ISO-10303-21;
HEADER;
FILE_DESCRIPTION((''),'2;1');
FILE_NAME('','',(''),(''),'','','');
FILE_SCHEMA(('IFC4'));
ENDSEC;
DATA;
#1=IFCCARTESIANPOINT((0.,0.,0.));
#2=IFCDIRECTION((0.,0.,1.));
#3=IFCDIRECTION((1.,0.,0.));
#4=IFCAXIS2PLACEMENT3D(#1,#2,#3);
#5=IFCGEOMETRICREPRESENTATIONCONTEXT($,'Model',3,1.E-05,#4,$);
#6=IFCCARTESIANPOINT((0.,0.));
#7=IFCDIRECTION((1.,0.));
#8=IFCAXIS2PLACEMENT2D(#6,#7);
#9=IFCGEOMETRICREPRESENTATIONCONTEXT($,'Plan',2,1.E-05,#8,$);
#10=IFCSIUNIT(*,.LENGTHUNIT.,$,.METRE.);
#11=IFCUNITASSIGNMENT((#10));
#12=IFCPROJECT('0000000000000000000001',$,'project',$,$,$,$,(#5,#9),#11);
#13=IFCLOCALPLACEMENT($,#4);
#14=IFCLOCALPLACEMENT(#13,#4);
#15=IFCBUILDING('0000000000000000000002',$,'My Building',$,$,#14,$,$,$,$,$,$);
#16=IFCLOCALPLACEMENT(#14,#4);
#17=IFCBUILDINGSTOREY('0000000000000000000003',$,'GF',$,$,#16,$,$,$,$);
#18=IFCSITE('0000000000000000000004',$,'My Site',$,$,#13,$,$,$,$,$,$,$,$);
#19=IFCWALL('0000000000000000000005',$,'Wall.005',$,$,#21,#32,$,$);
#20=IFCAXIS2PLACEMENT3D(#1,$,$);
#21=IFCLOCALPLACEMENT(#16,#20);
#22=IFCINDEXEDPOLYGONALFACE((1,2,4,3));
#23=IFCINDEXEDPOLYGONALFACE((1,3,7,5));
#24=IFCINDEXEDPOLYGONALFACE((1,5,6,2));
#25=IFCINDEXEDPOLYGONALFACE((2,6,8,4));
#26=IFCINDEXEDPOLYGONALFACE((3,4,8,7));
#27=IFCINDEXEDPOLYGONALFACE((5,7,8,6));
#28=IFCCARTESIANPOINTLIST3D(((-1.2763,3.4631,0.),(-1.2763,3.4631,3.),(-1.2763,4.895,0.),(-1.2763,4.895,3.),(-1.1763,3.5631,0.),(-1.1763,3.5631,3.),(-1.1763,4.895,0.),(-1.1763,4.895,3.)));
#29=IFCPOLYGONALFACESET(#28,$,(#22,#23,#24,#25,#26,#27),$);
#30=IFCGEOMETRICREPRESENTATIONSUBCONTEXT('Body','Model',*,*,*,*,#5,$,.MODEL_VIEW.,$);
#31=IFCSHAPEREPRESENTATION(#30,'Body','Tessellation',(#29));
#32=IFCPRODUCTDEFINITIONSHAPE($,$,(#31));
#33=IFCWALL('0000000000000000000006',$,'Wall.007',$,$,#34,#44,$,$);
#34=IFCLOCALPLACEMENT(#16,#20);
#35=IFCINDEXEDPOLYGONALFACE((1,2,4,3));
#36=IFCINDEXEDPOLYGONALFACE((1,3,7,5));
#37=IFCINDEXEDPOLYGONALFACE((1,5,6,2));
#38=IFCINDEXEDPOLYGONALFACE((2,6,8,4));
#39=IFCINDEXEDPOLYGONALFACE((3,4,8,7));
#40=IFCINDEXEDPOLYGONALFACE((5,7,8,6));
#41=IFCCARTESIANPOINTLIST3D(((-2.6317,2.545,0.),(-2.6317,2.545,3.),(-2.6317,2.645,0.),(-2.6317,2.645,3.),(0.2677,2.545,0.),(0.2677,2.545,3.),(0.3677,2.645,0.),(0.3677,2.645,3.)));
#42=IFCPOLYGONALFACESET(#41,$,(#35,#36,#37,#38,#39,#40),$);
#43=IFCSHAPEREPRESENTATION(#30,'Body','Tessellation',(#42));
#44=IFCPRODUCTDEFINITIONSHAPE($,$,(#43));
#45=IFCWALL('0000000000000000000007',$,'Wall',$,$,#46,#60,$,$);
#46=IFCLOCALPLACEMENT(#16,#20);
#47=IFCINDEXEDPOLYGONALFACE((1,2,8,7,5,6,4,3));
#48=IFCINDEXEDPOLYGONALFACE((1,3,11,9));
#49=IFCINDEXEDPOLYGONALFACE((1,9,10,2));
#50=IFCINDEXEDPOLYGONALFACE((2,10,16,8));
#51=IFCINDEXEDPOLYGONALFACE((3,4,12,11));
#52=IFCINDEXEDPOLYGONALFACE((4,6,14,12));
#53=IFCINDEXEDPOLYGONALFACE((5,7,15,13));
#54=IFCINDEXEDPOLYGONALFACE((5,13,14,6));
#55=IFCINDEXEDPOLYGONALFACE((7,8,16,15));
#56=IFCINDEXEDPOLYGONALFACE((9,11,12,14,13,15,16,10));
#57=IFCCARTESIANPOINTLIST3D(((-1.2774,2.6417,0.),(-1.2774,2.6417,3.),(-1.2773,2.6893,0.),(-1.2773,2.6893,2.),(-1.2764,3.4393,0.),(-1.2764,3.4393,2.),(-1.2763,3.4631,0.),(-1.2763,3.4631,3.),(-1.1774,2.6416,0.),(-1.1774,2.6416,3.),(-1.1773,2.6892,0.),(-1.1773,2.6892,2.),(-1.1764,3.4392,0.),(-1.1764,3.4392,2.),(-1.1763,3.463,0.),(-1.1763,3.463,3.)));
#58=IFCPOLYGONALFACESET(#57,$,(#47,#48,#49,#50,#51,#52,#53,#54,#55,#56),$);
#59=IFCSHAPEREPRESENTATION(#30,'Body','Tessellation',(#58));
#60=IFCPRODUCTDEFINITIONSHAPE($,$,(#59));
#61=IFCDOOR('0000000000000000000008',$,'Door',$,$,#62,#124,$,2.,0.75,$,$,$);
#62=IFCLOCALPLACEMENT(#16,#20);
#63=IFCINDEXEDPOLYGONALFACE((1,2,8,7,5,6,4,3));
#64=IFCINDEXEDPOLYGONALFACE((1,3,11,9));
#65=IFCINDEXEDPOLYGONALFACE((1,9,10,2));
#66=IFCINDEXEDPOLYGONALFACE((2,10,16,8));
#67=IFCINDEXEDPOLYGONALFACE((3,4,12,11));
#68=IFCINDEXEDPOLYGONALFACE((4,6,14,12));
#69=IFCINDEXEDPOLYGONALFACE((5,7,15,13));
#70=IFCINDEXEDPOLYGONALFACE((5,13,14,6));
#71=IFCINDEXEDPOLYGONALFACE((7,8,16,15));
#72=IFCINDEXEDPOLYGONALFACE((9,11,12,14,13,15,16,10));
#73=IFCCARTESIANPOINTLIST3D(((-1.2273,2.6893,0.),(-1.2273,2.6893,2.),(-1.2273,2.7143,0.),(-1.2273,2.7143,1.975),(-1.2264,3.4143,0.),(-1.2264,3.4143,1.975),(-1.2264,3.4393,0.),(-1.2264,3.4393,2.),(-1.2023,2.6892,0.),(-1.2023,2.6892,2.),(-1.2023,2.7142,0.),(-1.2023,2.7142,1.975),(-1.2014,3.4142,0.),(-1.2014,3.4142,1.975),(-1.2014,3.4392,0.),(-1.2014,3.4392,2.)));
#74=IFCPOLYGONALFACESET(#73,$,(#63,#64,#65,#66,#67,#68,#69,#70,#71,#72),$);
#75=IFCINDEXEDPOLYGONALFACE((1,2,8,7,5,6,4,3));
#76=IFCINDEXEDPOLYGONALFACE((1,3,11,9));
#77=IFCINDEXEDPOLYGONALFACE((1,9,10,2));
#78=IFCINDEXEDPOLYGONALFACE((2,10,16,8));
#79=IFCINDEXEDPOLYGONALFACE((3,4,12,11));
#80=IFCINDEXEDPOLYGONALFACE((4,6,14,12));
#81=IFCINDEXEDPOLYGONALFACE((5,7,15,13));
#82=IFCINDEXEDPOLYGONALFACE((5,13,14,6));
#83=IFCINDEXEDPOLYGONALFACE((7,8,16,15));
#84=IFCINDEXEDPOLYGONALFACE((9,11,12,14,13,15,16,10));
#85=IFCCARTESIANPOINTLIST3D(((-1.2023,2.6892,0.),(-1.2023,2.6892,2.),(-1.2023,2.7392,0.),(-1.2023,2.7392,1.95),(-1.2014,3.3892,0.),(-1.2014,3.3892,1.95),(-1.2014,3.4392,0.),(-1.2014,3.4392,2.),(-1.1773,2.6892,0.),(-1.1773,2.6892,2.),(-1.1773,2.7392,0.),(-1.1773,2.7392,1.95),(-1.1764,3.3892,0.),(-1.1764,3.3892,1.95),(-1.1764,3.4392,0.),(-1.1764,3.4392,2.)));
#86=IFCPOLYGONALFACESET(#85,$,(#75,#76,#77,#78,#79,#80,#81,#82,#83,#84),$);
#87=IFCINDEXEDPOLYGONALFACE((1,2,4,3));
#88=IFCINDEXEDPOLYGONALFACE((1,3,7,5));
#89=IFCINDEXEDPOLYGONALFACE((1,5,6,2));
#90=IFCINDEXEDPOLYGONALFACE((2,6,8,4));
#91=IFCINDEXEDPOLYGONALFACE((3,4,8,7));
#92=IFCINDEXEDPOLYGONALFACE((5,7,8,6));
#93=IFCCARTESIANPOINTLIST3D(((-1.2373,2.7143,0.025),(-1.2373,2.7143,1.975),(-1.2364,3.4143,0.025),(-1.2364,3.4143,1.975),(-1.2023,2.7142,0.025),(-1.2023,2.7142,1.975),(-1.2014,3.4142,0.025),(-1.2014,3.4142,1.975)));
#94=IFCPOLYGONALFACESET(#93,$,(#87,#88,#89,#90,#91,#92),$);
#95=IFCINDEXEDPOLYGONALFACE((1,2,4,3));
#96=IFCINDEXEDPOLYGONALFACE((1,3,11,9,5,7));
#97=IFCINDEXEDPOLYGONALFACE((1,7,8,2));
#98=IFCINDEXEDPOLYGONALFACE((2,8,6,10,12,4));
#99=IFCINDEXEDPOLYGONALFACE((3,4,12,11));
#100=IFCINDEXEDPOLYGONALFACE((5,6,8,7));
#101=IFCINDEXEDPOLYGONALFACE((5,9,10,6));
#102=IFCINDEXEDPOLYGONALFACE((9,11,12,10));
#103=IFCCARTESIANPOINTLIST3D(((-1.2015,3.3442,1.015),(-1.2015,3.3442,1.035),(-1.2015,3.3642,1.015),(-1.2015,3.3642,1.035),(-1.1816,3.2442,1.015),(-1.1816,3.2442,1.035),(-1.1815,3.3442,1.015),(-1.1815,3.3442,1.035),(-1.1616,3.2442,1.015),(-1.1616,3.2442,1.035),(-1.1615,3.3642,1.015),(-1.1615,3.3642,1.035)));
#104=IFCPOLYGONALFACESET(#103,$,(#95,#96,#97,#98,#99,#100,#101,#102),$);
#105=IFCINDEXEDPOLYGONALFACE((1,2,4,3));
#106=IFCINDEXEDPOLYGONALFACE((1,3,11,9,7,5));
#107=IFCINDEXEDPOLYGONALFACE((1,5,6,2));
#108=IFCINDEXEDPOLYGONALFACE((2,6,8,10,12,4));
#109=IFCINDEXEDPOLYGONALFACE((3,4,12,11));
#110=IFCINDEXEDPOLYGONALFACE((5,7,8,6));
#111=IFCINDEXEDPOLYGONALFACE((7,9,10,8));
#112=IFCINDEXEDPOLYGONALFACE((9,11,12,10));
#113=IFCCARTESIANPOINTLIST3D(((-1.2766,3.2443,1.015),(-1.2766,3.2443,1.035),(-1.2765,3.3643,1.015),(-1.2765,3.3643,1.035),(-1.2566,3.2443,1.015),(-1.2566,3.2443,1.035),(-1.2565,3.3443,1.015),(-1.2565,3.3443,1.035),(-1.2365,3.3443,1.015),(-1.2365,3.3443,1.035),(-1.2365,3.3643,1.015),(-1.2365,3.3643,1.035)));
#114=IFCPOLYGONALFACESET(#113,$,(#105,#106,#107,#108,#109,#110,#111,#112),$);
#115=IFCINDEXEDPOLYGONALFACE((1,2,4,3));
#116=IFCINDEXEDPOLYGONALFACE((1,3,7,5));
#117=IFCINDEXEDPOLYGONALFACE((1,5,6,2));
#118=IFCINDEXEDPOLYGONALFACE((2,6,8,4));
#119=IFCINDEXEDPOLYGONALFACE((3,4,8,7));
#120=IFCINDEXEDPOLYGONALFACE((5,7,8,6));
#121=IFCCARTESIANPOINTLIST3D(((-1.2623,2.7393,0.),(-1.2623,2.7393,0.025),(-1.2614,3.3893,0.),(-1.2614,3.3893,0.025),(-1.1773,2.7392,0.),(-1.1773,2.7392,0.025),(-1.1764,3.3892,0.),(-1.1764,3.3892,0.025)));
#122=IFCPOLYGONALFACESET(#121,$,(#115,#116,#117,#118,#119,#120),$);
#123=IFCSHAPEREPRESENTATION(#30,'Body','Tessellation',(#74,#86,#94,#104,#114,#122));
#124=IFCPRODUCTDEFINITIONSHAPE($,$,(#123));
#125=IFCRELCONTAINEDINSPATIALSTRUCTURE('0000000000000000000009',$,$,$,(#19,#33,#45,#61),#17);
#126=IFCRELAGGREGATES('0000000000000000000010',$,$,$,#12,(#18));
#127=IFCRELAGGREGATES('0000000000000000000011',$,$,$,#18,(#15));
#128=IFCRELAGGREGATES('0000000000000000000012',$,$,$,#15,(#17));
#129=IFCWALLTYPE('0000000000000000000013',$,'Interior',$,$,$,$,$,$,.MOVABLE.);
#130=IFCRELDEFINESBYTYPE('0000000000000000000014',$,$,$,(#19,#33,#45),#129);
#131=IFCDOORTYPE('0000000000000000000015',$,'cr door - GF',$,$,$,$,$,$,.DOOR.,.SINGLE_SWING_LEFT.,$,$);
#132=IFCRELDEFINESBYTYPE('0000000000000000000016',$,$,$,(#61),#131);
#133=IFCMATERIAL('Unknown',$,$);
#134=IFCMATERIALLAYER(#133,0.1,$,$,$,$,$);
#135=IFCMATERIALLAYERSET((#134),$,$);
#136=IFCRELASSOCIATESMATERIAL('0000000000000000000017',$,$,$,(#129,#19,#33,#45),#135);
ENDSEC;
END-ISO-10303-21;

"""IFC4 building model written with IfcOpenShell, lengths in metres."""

from ifc_helpers import new_model, entity, si_unit, frame, origin_with_axes, origin_2d_with_axis, place, context, subcontext, project, spatial, line, indexed_curve, outline, extrude, shape, source, transform, mapped, material, layer, layer_set, layer_usage, type_object, type_shapes, element, fill, save


model = new_model("IFC4")

# Units and contexts
model_context = context("Model", 3, precision=1e-05, world=origin_with_axes())
plan_context = context("Plan", 2, precision=1e-05, world=origin_2d_with_axis())
body_context_1 = subcontext(model_context, "Body", "Model", "MODEL_VIEW")
body_context_2 = subcontext(plan_context, "Body", "Plan", "PLAN_VIEW")
ifc_project = project(units=[si_unit("LENGTHUNIT", "METRE")], contexts=[model_context, plan_context])

# Site, building, storey
site_placement = place(None, origin_with_axes())
site = spatial("IfcSite", under=ifc_project, at=site_placement, Name="My Site")
building_placement = place(site_placement, origin_with_axes())
building = spatial("IfcBuilding", under=site, at=building_placement, Name="My Building")
storey_placement = place(building_placement, origin_with_axes())
storey = spatial("IfcBuildingStorey", under=building, at=storey_placement, Name="GF")

# Shared definitions
ifc_material = material(Name="Unknown")

# Walls
ifc_layer_1 = layer(ifc_material, 0.1)
ifc_layer_set_1 = layer_set([ifc_layer_1])
wall_type_1 = type_object("IfcWallType", Name="Interior", PredefinedType="MOVABLE", material=ifc_layer_set_1)
ifc_layer_usage_1 = layer_usage(ifc_layer_set_1, "AXIS2", "POSITIVE", 0.0)
wall_1_placement = place(storey_placement, frame((-1.1763, 3.5631, 0.0), z_axis=(0.0, 0.0, 1.0), x_axis=(0.0, 1.0, 0.0)))
element("IfcWall", 1, at=wall_1_placement, inside=storey, type_object=wall_type_1, material=ifc_layer_usage_1, Name="Wall.005", context=body_context_1, shape_type="SweptSolid", body=[
    extrude(outline(indexed_curve([(0.0, 0.0), (-0.1, 0.1), (1.3318, 0.1), (1.3318, 0.0)], segments=[line(1, 2, 3, 4, 1)])), origin_with_axes(), (0.0, 0.0, 1.0), 3.0),
])
ifc_layer_usage_2 = layer_usage(ifc_layer_set_1, "AXIS2", "POSITIVE", 0.0)
wall_2_placement = place(storey_placement, frame((0.3677, 2.645, 0.0), z_axis=(0.0, 0.0, 1.0), x_axis=(-1.0, 0.0, 0.0)))
element("IfcWall", 2, at=wall_2_placement, inside=storey, type_object=wall_type_1, material=ifc_layer_usage_2, Name="Wall.007", context=body_context_1, shape_type="SweptSolid", body=[
    extrude(outline(indexed_curve([(0.0, 0.0), (0.1, 0.1), (2.9994, 0.1), (2.9994, 0.0)], segments=[line(1, 2, 3, 4, 1)])), origin_with_axes(), (0.0, 0.0, 1.0), 3.0),
])

# Wall, opening, door
ifc_layer_usage_3 = layer_usage(ifc_layer_set_1, "AXIS2", "POSITIVE", 0.0)
wall_3_placement = place(storey_placement, frame((-1.2763, 3.4631, 0.0), z_axis=(0.0, 0.0, 1.0), x_axis=(-0.001302, -0.999999, 0.0)))
wall_3 = element("IfcWall", 3, at=wall_3_placement, inside=storey, type_object=wall_type_1, material=ifc_layer_usage_3, Name="Wall", context=body_context_1, shape_type="SweptSolid", body=[
    extrude(outline(indexed_curve([(0.0, 0.0), (0.0, 0.1), (0.8215, 0.1), (0.8215, 0.0)], segments=[line(1, 2, 3, 4, 1)])), origin_with_axes(), (0.0, 0.0, 1.0), 3.0),
])
shared_shape_1 = source(origin_with_axes(), body_context_1, "Body", "SweptSolid", [
    extrude(outline(indexed_curve([(0.0, 0.0), (0.75, 0.0), (0.75, 2.0), (0.0, 2.0)], segments=[line(1, 2, 3, 4, 1)])), frame((0.0, -0.6, 0.0), z_axis=(0.0, -1.0, 0.0), x_axis=(1.0, 0.0, 0.0)), (0.0, 0.0, -1.0), 1.2),
])
opening_1_placement = place(wall_3_placement, frame((0.7738, 0.1, 0.0), z_axis=(0.0, 0.0, 1.0), x_axis=(-1.0, 0.0, 0.0)))
opening_1 = element("IfcOpeningElement", 4, at=opening_1_placement, cuts=wall_3, PredefinedType="OPENING", context=body_context_1, shape_type="MappedRepresentation", body=[
    mapped(shared_shape_1, transform((0.0, 0.0, 0.0), x_axis=(1.0, 0.0, 0.0), y_axis=(0.0, 1.0, 0.0), z_axis=(0.0, 0.0, 1.0), scale=1.0)),
])
door_type_1 = type_object("IfcDoorType", Name="cr door - GF", OperationType="SINGLE_SWING_LEFT", PredefinedType="DOOR")
shared_shape_2 = source(origin_with_axes(), body_context_1, "Body", "SweptSolid", [
    extrude(outline(indexed_curve([(0.0, 0.0), (0.0, 2.0), (0.75, 2.0), (0.75, 0.0), (0.725, 0.0), (0.725, 1.975), (0.025, 1.975), (0.025, 0.0)], segments=[line(1, 2, 3, 4, 5, 6, 7, 8, 1)])), frame((0.0, 0.025, 0.0), z_axis=(0.0, -1.0, 0.0), x_axis=(1.0, 0.0, 0.0)), (0.0, 0.0, -1.0), 0.025),
    extrude(outline(indexed_curve([(0.0, 0.0), (0.0, 2.0), (0.75, 2.0), (0.75, 0.0), (0.7, 0.0), (0.7, 1.95), (0.05, 1.95), (0.05, 0.0)], segments=[line(1, 2, 3, 4, 5, 6, 7, 8, 1)])), frame((0.0, 0.0, 0.0), z_axis=(0.0, -1.0, 0.0), x_axis=(1.0, 0.0, 0.0)), (0.0, 0.0, -1.0), 0.025),
    extrude(outline(indexed_curve([(0.0, 0.0), (0.7, 0.0), (0.7, 0.035), (0.0, 0.035)], segments=[line(1, 2, 3, 4, 1)])), frame((0.025, 0.025, 0.025), z_axis=(0.0, 0.0, 1.0), x_axis=(1.0, 0.0, 0.0)), (0.0, 0.0, 1.0), 1.95),
    extrude(outline(indexed_curve([(0.0, 0.0), (0.0, -0.04), (-0.12, -0.04), (-0.12, -0.02), (-0.02, -0.02), (-0.02, 0.0)], segments=[line(1, 2, 3, 4, 5, 6, 1)])), frame((0.675, 0.025, 1.015), z_axis=(0.0, 0.0, 1.0), x_axis=(1.0, 0.0, 0.0)), (0.0, 0.0, 1.0), 0.02),
    extrude(outline(indexed_curve([(0.0, 0.0), (0.0, 0.04), (-0.12, 0.04), (-0.12, 0.02), (-0.02, 0.02), (-0.02, 0.0)], segments=[line(1, 2, 3, 4, 5, 6, 1)])), frame((0.675, 0.06, 1.015), z_axis=(0.0, 0.0, 1.0), x_axis=(1.0, 0.0, 0.0)), (0.0, 0.0, 1.0), 0.02),
    extrude(outline(indexed_curve([(0.0, 0.0), (0.65, 0.0), (0.65, 0.085), (0.0, 0.085)], segments=[line(1, 2, 3, 4, 1)])), frame((0.05, 0.0, 0.0), z_axis=(0.0, 0.0, 1.0), x_axis=(1.0, 0.0, 0.0)), (0.0, 0.0, 1.0), 0.025),
])
shared_shape_3 = source(origin_with_axes(), body_context_2, "Body", "Curve2D", [
    entity("IfcIndexedPolyCurve", entity("IfcCartesianPointList2D", [[0.0, 0.0], [0.0, 0.05], [0.025, 0.05], [0.025, 0.025], [0.05, 0.025], [0.05, 0.0]]), [entity("IfcLineIndex", [1, 2, 3, 4, 5, 6, 1])]),
    entity("IfcIndexedPolyCurve", entity("IfcCartesianPointList2D", [[0.75, 0.0], [0.75, 0.05], [0.725, 0.05], [0.725, 0.025], [0.7, 0.025], [0.7, 0.0]]), [entity("IfcLineIndex", [1, 2, 3, 4, 5, 6, 1])]),
    entity("IfcTrimmedCurve", entity("IfcEllipse", entity("IfcAxis2Placement2D", entity("IfcCartesianPoint", [0.06, 0.05]), entity("IfcDirection", [1.0, 0.0])), 0.665, 0.7), [entity("IfcCartesianPoint", [0.725, 0.05])], [entity("IfcCartesianPoint", [0.06, 0.75])], True, "CARTESIAN"),
    entity("IfcIndexedPolyCurve", entity("IfcCartesianPointList2D", [[0.025, 0.05], [0.06, 0.05], [0.06, 0.75], [0.025, 0.75]]), [entity("IfcLineIndex", [1, 2, 3, 4, 1])]),
])
type_shapes(door_type_1, [shared_shape_2, shared_shape_3])
door_1_placement = place(opening_1_placement, frame((0.0, 0.0, 0.0), z_axis=(0.0, 0.0, 1.0), x_axis=(1.0, 0.0, 0.0)))
door_1 = element("IfcDoor", 5, at=door_1_placement, inside=storey, type_object=door_type_1, Name="Door", OverallHeight=2.0, OverallWidth=0.75, shapes=[
    shape(body_context_1, "Body", "MappedRepresentation", [mapped(shared_shape_2, transform((0.0, 0.0, 0.0), x_axis=(1.0, 0.0, 0.0), y_axis=(0.0, 1.0, 0.0), z_axis=(0.0, 0.0, 1.0), scale=1.0))]),
    shape(body_context_2, "Body", "MappedRepresentation", [mapped(shared_shape_3, transform((0.0, 0.0, 0.0), x_axis=(1.0, 0.0, 0.0), y_axis=(0.0, 1.0, 0.0), z_axis=(0.0, 0.0, 1.0), scale=1.0))]),
])
fill(opening_1, door_1)

save(model, "model.ifc")
